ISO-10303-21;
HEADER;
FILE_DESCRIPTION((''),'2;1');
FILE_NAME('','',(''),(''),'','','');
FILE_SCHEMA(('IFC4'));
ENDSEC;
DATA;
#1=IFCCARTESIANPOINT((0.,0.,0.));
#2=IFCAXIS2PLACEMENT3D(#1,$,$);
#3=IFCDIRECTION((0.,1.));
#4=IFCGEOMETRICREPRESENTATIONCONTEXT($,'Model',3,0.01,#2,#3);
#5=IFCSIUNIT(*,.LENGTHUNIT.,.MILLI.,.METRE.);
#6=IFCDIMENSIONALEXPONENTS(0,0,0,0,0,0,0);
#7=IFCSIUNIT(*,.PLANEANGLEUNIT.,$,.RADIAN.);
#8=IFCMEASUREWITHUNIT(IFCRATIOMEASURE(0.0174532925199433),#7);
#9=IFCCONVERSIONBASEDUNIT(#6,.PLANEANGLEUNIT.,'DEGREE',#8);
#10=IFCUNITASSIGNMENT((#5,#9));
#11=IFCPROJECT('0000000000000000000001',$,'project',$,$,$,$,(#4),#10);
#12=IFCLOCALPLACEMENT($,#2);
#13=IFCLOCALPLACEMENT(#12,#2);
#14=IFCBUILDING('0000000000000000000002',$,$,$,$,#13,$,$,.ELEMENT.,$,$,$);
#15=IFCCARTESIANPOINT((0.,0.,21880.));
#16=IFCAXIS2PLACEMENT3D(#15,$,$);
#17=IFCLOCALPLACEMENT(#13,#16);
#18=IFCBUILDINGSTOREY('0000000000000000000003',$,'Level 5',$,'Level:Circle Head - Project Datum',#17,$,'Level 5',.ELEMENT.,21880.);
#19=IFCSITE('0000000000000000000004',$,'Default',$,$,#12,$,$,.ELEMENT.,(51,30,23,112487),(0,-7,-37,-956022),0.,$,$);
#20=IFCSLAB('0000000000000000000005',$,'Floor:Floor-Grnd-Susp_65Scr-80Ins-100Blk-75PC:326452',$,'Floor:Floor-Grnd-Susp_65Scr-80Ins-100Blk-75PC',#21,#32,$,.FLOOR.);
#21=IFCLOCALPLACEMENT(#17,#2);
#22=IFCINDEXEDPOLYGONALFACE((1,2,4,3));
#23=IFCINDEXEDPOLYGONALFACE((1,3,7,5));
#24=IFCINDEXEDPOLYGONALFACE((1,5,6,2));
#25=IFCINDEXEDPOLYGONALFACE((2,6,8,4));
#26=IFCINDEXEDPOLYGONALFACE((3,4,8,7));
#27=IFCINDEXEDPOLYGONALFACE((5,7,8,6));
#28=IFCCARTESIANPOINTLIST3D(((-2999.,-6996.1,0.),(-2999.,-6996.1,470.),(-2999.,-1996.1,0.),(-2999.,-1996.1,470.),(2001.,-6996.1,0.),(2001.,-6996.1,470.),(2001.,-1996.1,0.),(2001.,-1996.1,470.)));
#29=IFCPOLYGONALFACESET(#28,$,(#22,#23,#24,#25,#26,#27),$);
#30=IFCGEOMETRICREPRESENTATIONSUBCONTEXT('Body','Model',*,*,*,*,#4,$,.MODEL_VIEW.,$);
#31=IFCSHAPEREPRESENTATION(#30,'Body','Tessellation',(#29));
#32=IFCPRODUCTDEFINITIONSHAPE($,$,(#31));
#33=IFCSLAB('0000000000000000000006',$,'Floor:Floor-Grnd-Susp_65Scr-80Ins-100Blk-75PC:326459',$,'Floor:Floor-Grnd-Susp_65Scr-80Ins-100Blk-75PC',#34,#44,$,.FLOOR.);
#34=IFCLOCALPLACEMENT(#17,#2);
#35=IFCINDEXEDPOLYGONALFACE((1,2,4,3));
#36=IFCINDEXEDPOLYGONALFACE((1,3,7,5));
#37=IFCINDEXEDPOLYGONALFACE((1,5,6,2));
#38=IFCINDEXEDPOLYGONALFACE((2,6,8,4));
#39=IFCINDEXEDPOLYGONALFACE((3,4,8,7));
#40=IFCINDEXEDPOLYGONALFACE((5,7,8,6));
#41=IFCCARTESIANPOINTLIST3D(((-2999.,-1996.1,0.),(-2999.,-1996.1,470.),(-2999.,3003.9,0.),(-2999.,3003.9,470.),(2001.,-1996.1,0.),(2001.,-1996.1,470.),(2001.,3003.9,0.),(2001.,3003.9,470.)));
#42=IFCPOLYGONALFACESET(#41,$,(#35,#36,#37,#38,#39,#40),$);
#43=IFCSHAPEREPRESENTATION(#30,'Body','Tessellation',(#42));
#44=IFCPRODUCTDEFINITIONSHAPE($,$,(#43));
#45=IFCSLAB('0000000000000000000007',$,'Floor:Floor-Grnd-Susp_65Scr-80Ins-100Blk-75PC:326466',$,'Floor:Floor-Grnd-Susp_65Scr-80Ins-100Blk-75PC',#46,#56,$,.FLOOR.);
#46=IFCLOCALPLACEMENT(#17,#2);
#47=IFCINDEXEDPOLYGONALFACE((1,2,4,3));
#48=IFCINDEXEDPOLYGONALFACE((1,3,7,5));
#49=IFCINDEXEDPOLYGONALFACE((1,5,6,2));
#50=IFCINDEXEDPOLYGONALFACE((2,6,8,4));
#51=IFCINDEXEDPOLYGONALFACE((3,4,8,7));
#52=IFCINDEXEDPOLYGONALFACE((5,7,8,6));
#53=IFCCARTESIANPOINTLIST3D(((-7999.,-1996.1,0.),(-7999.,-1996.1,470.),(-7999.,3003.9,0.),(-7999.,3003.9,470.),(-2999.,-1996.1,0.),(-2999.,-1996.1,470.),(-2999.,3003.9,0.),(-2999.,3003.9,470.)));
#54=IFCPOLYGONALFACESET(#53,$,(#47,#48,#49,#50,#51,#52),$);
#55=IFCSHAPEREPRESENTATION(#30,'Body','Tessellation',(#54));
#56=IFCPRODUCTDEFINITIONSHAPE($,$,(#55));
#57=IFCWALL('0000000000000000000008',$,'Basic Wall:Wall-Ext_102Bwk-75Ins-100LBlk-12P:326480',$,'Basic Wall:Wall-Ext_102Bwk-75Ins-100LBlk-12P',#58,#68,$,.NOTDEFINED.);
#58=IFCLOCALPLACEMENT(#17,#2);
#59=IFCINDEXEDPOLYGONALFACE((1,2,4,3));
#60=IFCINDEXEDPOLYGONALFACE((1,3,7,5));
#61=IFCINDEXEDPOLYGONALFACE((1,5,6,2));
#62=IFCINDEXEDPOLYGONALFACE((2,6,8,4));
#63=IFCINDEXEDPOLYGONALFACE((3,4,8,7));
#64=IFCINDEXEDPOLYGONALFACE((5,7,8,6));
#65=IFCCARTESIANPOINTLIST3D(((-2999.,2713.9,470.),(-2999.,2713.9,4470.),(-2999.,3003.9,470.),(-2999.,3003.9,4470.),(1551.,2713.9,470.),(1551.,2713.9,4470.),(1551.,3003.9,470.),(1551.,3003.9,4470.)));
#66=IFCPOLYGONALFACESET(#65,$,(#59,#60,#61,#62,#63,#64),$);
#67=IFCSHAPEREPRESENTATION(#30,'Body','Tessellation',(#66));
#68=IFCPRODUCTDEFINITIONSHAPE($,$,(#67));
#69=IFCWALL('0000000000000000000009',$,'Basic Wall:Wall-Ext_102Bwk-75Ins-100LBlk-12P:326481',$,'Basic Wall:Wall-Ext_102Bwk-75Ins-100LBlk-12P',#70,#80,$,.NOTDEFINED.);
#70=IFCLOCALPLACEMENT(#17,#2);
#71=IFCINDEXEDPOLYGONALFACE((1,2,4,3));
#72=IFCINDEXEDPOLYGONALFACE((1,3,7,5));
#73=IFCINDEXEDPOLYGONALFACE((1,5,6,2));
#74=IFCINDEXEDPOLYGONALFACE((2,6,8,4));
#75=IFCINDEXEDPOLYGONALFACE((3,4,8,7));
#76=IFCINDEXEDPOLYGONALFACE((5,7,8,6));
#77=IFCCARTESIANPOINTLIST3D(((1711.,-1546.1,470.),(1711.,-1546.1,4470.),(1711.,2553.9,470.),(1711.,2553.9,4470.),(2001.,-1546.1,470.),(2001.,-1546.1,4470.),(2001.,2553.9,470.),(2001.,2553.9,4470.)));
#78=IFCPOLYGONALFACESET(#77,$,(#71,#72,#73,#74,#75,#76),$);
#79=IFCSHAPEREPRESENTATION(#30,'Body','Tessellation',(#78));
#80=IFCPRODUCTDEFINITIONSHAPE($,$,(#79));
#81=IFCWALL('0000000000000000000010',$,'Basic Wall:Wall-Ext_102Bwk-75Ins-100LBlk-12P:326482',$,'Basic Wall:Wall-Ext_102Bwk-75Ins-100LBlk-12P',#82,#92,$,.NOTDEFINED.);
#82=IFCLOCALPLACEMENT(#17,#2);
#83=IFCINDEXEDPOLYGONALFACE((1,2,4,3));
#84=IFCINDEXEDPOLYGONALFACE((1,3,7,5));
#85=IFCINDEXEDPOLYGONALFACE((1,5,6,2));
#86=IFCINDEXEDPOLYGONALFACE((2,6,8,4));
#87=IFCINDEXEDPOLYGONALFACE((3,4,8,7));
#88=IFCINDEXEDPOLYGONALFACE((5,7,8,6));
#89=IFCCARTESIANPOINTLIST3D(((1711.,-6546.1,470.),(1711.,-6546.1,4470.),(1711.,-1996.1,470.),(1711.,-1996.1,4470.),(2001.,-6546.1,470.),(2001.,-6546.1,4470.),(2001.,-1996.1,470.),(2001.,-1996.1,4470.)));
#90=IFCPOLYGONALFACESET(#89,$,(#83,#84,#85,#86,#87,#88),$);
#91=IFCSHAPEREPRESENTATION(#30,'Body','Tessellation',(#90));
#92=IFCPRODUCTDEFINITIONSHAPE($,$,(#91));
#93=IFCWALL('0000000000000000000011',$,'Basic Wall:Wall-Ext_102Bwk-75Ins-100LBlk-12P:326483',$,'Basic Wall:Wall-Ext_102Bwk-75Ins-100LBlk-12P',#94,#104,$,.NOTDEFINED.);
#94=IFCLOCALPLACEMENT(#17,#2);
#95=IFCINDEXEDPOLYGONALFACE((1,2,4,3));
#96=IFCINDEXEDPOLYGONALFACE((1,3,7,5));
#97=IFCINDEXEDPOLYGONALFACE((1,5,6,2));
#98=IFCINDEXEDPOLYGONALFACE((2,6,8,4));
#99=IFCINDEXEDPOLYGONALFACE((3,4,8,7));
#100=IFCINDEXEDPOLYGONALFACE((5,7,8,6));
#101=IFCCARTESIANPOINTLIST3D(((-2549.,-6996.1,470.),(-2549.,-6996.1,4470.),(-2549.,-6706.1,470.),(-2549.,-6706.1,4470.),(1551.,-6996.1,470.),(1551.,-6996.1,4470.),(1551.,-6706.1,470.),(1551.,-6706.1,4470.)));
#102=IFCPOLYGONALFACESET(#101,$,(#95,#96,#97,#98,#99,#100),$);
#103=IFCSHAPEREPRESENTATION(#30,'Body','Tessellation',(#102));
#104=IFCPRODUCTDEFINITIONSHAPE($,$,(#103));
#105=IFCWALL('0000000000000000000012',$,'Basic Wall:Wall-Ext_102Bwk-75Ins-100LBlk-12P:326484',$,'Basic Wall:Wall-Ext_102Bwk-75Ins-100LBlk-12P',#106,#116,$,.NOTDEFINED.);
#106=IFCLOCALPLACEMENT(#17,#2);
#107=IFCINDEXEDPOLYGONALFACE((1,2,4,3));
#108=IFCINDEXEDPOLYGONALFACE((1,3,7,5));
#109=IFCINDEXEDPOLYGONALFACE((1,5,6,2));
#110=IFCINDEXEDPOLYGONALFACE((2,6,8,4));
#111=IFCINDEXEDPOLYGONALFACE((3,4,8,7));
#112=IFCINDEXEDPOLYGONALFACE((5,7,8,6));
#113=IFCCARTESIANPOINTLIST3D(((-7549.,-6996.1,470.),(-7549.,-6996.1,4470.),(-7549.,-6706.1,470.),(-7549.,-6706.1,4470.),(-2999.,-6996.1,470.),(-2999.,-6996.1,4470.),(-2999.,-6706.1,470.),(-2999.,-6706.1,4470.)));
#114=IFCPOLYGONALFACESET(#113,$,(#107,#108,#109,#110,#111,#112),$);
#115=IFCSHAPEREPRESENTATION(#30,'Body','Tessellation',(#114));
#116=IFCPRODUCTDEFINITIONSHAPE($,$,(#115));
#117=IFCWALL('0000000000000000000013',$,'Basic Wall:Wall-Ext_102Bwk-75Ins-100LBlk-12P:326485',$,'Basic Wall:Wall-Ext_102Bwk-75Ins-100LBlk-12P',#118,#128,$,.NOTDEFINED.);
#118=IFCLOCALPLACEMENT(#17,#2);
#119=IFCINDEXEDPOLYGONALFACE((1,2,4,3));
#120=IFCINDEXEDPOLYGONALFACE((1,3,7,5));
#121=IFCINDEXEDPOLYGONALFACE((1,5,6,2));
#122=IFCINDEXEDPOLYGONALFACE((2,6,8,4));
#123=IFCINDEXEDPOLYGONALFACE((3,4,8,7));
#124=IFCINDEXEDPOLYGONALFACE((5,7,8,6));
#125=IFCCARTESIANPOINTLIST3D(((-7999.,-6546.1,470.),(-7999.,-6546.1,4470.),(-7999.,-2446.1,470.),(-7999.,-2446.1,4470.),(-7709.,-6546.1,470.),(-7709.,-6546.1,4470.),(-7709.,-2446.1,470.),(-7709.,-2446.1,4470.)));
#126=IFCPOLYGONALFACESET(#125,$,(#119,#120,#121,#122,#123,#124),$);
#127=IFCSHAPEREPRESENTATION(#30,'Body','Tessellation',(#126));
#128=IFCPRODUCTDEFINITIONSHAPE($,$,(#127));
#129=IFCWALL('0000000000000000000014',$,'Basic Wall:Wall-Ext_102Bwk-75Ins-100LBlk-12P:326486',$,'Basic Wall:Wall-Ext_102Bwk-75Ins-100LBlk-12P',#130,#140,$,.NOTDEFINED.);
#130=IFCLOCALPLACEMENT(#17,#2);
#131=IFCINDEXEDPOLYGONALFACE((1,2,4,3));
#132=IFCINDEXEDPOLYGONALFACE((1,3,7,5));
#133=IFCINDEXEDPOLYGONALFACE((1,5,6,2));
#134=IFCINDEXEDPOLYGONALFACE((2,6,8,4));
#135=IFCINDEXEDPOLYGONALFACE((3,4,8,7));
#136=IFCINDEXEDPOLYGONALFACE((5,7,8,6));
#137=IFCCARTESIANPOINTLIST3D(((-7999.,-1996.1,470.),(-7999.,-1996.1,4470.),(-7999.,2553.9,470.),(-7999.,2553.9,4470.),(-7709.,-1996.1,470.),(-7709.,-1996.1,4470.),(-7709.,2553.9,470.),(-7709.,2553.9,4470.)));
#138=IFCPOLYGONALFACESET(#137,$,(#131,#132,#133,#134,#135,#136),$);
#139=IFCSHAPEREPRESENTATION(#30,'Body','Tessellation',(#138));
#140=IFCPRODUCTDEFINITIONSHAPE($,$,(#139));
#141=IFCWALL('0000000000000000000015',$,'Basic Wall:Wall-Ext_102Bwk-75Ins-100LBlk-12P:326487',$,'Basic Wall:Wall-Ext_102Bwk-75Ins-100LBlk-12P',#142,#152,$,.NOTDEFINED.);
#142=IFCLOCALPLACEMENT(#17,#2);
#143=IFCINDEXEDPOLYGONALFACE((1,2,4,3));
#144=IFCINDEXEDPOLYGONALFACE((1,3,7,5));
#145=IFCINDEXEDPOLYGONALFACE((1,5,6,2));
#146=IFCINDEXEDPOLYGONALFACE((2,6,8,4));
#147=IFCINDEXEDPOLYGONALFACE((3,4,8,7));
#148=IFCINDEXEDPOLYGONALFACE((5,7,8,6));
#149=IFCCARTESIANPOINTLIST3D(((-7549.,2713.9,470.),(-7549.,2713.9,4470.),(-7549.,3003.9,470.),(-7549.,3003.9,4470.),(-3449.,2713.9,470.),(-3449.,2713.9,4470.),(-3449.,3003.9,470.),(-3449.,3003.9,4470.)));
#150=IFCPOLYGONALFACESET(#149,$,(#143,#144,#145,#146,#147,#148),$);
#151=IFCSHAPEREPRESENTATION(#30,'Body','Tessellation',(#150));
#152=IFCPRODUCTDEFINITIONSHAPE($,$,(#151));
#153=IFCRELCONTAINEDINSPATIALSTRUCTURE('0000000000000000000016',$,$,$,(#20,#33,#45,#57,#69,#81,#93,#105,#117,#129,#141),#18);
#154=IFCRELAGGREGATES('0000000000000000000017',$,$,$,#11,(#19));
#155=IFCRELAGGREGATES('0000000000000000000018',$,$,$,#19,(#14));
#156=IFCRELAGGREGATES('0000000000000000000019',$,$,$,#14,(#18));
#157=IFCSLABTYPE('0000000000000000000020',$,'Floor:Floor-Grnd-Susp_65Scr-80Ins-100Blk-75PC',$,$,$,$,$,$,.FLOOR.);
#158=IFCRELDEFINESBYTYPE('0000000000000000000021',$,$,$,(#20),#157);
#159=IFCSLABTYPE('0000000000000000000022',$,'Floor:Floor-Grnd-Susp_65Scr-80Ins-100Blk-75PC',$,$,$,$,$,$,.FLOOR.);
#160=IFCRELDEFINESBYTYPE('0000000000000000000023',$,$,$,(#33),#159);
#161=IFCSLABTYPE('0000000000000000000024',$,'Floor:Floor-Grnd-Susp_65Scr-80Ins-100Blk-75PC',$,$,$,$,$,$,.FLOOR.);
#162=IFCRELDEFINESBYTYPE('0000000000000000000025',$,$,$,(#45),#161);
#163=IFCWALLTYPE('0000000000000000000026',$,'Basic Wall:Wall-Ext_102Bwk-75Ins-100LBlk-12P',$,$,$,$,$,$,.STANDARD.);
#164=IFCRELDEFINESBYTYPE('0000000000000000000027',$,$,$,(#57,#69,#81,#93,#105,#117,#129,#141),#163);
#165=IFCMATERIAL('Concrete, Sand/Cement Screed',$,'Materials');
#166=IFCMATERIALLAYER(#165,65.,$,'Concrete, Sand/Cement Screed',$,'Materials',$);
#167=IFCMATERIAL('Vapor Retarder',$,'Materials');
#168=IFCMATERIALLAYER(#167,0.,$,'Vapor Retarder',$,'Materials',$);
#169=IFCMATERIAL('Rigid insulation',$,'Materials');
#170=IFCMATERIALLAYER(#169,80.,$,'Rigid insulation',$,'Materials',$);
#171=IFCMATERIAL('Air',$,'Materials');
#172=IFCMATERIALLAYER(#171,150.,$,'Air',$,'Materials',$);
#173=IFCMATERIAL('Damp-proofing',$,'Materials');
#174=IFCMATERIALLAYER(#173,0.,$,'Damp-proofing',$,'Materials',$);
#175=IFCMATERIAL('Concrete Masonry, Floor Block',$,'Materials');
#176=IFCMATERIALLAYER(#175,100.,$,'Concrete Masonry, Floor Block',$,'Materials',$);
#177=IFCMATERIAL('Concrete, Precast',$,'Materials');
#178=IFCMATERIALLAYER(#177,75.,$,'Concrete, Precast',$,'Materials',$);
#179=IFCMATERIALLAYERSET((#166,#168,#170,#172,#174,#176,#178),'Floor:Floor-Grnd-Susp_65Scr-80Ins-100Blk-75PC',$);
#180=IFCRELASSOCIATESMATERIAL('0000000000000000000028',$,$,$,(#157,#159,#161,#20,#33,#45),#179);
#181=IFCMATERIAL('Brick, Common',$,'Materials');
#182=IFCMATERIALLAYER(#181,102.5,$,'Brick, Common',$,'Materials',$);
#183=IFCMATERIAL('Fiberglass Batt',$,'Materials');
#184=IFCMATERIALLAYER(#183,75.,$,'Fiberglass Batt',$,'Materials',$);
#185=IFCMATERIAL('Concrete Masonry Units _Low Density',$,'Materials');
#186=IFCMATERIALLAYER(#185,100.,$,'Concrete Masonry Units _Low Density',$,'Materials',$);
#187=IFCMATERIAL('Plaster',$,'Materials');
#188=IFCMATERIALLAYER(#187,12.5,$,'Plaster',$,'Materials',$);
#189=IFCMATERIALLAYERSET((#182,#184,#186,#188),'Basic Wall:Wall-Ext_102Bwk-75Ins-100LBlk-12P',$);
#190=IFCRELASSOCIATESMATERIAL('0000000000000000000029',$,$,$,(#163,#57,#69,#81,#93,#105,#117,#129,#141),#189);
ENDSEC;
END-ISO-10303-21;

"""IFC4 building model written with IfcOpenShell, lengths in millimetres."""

from ifc_helpers import new_model, entity, si_unit, converted_unit, direction, frame, frame_2d, origin, origin_2d_with_axis, place, context, subcontext, project, spatial, rectangle, extrude, material, layer, layer_set, layer_usage, type_object, element, save


model = new_model("IFC4")

# Units and contexts
model_context = context("Model", 3, precision=0.01, world=origin(), true_north=direction((0.0, 1.0)))
body_context = subcontext(model_context, "Body", "Model", "MODEL_VIEW")
ifc_project = project(units=[si_unit("LENGTHUNIT", "METRE", prefix="MILLI"), converted_unit("PLANEANGLEUNIT", "DEGREE", entity("IfcRatioMeasure", 0.0174532925199433), si_unit("PLANEANGLEUNIT", "RADIAN"), dimensions=[0, 0, 0, 0, 0, 0, 0])], contexts=[model_context])

# Site, building, storey
site_placement = place(None, origin())
site = spatial("IfcSite", under=ifc_project, at=site_placement, Name="Default", CompositionType="ELEMENT", RefLatitude=(51, 30, 23, 112487), RefLongitude=(0, -7, -37, -956022), RefElevation=0.0)
building_placement = place(site_placement, origin())
building = spatial("IfcBuilding", under=site, at=building_placement, CompositionType="ELEMENT")
storey_placement = place(building_placement, frame((0.0, 0.0, 21880.0)))
storey = spatial("IfcBuildingStorey", under=building, at=storey_placement, Name="Level 5", ObjectType="Level:Circle Head - Project Datum", LongName="Level 5", CompositionType="ELEMENT", Elevation=21880.0)

# Slabs
ifc_material_1 = material(Name="Concrete, Sand/Cement Screed", Category="Materials")
ifc_layer_1 = layer(ifc_material_1, 65.0, Name="Concrete, Sand/Cement Screed", Category="Materials")
ifc_material_2 = material(Name="Vapor Retarder", Category="Materials")
ifc_layer_2 = layer(ifc_material_2, 0.0, Name="Vapor Retarder", Category="Materials")
ifc_material_3 = material(Name="Rigid insulation", Category="Materials")
ifc_layer_3 = layer(ifc_material_3, 80.0, Name="Rigid insulation", Category="Materials")
ifc_material_4 = material(Name="Air", Category="Materials")
ifc_layer_4 = layer(ifc_material_4, 150.0, Name="Air", Category="Materials")
ifc_material_5 = material(Name="Damp-proofing", Category="Materials")
ifc_layer_5 = layer(ifc_material_5, 0.0, Name="Damp-proofing", Category="Materials")
ifc_material_6 = material(Name="Concrete Masonry, Floor Block", Category="Materials")
ifc_layer_6 = layer(ifc_material_6, 100.0, Name="Concrete Masonry, Floor Block", Category="Materials")
ifc_material_7 = material(Name="Concrete, Precast", Category="Materials")
ifc_layer_7 = layer(ifc_material_7, 75.0, Name="Concrete, Precast", Category="Materials")
ifc_layer_set_1 = layer_set([ifc_layer_1, ifc_layer_2, ifc_layer_3, ifc_layer_4, ifc_layer_5, ifc_layer_6, ifc_layer_7], Name="Floor:Floor-Grnd-Susp_65Scr-80Ins-100Blk-75PC")
ifc_layer_usage_1 = layer_usage(ifc_layer_set_1, "AXIS3", "POSITIVE", 0.0)
slab_type_1 = type_object("IfcSlabType", Name="Floor:Floor-Grnd-Susp_65Scr-80Ins-100Blk-75PC", PredefinedType="FLOOR", material=ifc_layer_set_1)
slab_1_placement = place(storey_placement, origin())
element("IfcSlab", 1, at=slab_1_placement, inside=storey, type_object=slab_type_1, material=ifc_layer_usage_1, Name="Floor:Floor-Grnd-Susp_65Scr-80Ins-100Blk-75PC:326452", ObjectType="Floor:Floor-Grnd-Susp_65Scr-80Ins-100Blk-75PC", PredefinedType="FLOOR", context=body_context, shape_type="SweptSolid", body=[
    extrude(rectangle(XDim=5000.0, YDim=5000.0, at=frame_2d((0.0, 0.0), x_axis=(1.0, 0.0))), frame((-499.0, -4496.1, 470.0), z_axis=(0.0, 0.0, -1.0), x_axis=(0.0, 1.0, 0.0)), (0.0, 0.0, 1.0), 470.0),
])
ifc_layer_usage_2 = layer_usage(ifc_layer_set_1, "AXIS3", "POSITIVE", 0.0)
slab_type_2 = type_object("IfcSlabType", Name="Floor:Floor-Grnd-Susp_65Scr-80Ins-100Blk-75PC", PredefinedType="FLOOR", material=ifc_layer_set_1)
slab_2_placement = place(storey_placement, origin())
element("IfcSlab", 2, at=slab_2_placement, inside=storey, type_object=slab_type_2, material=ifc_layer_usage_2, Name="Floor:Floor-Grnd-Susp_65Scr-80Ins-100Blk-75PC:326459", ObjectType="Floor:Floor-Grnd-Susp_65Scr-80Ins-100Blk-75PC", PredefinedType="FLOOR", context=body_context, shape_type="SweptSolid", body=[
    extrude(rectangle(XDim=5000.0, YDim=5000.0, at=origin_2d_with_axis()), frame((-499.0, 503.9, 470.0), z_axis=(0.0, 0.0, -1.0), x_axis=(0.0, 1.0, 0.0)), (0.0, 0.0, 1.0), 470.0),
])
ifc_layer_usage_3 = layer_usage(ifc_layer_set_1, "AXIS3", "POSITIVE", 0.0)
slab_type_3 = type_object("IfcSlabType", Name="Floor:Floor-Grnd-Susp_65Scr-80Ins-100Blk-75PC", PredefinedType="FLOOR", material=ifc_layer_set_1)
slab_3_placement = place(storey_placement, origin())
element("IfcSlab", 3, at=slab_3_placement, inside=storey, type_object=slab_type_3, material=ifc_layer_usage_3, Name="Floor:Floor-Grnd-Susp_65Scr-80Ins-100Blk-75PC:326466", ObjectType="Floor:Floor-Grnd-Susp_65Scr-80Ins-100Blk-75PC", PredefinedType="FLOOR", context=body_context, shape_type="SweptSolid", body=[
    extrude(rectangle(XDim=5000.0, YDim=5000.0, at=origin_2d_with_axis()), frame((-5499.0, 503.9, 470.0), z_axis=(0.0, 0.0, -1.0), x_axis=(0.0, 1.0, 0.0)), (0.0, 0.0, 1.0), 470.0),
])

# Walls
ifc_material_8 = material(Name="Brick, Common", Category="Materials")
ifc_layer_8 = layer(ifc_material_8, 102.5, Name="Brick, Common", Category="Materials")
ifc_material_9 = material(Name="Fiberglass Batt", Category="Materials")
ifc_layer_9 = layer(ifc_material_9, 75.0, Name="Fiberglass Batt", Category="Materials")
ifc_material_10 = material(Name="Concrete Masonry Units _Low Density", Category="Materials")
ifc_layer_10 = layer(ifc_material_10, 100.0, Name="Concrete Masonry Units _Low Density", Category="Materials")
ifc_material_11 = material(Name="Plaster", Category="Materials")
ifc_layer_11 = layer(ifc_material_11, 12.5, Name="Plaster", Category="Materials")
ifc_layer_set_2 = layer_set([ifc_layer_8, ifc_layer_9, ifc_layer_10, ifc_layer_11], Name="Basic Wall:Wall-Ext_102Bwk-75Ins-100LBlk-12P")
ifc_layer_usage_4 = layer_usage(ifc_layer_set_2, "AXIS2", "NEGATIVE", 145.0)
wall_type = type_object("IfcWallType", Name="Basic Wall:Wall-Ext_102Bwk-75Ins-100LBlk-12P", PredefinedType="STANDARD", material=ifc_layer_set_2)
wall_1_placement = place(storey_placement, frame((-2999.0, 2858.9, 470.0)))
element("IfcWall", 4, at=wall_1_placement, inside=storey, type_object=wall_type, material=ifc_layer_usage_4, Name="Basic Wall:Wall-Ext_102Bwk-75Ins-100LBlk-12P:326480", ObjectType="Basic Wall:Wall-Ext_102Bwk-75Ins-100LBlk-12P", PredefinedType="NOTDEFINED", context=body_context, shape_type="SweptSolid", body=[
    extrude(rectangle(XDim=4550.0, YDim=290.0, at=frame_2d((2275.0, 0.0), x_axis=(-1.0, 0.0))), origin(), (0.0, 0.0, 1.0), 4000.0),
])
ifc_layer_usage_5 = layer_usage(ifc_layer_set_2, "AXIS2", "NEGATIVE", 145.0)
wall_2_placement = place(storey_placement, frame((1856.0, 2553.9, 470.0), z_axis=(0.0, 0.0, 1.0), x_axis=(0.0, -1.0, 0.0)))
element("IfcWall", 5, at=wall_2_placement, inside=storey, type_object=wall_type, material=ifc_layer_usage_5, Name="Basic Wall:Wall-Ext_102Bwk-75Ins-100LBlk-12P:326481", ObjectType="Basic Wall:Wall-Ext_102Bwk-75Ins-100LBlk-12P", PredefinedType="NOTDEFINED", context=body_context, shape_type="SweptSolid", body=[
    extrude(rectangle(XDim=4100.0, YDim=290.0, at=frame_2d((2050.0, 0.0), x_axis=(-1.0, 0.0))), origin(), (0.0, 0.0, 1.0), 4000.0),
])
ifc_layer_usage_6 = layer_usage(ifc_layer_set_2, "AXIS2", "NEGATIVE", 145.0)
wall_3_placement = place(storey_placement, frame((1856.0, -1996.1, 470.0), z_axis=(0.0, 0.0, 1.0), x_axis=(0.0, -1.0, 0.0)))
element("IfcWall", 6, at=wall_3_placement, inside=storey, type_object=wall_type, material=ifc_layer_usage_6, Name="Basic Wall:Wall-Ext_102Bwk-75Ins-100LBlk-12P:326482", ObjectType="Basic Wall:Wall-Ext_102Bwk-75Ins-100LBlk-12P", PredefinedType="NOTDEFINED", context=body_context, shape_type="SweptSolid", body=[
    extrude(rectangle(XDim=4550.0, YDim=290.0, at=frame_2d((2275.0, 0.0), x_axis=(-1.0, 0.0))), origin(), (0.0, 0.0, 1.0), 4000.0),
])
ifc_layer_usage_7 = layer_usage(ifc_layer_set_2, "AXIS2", "NEGATIVE", 145.0)
wall_4_placement = place(storey_placement, frame((1551.0, -6851.1, 470.0), z_axis=(0.0, 0.0, 1.0), x_axis=(-1.0, 0.0, 0.0)))
element("IfcWall", 7, at=wall_4_placement, inside=storey, type_object=wall_type, material=ifc_layer_usage_7, Name="Basic Wall:Wall-Ext_102Bwk-75Ins-100LBlk-12P:326483", ObjectType="Basic Wall:Wall-Ext_102Bwk-75Ins-100LBlk-12P", PredefinedType="NOTDEFINED", context=body_context, shape_type="SweptSolid", body=[
    extrude(rectangle(XDim=4100.0, YDim=290.0, at=frame_2d((2050.0, 0.0), x_axis=(-1.0, 0.0))), origin(), (0.0, 0.0, 1.0), 4000.0),
])
ifc_layer_usage_8 = layer_usage(ifc_layer_set_2, "AXIS2", "NEGATIVE", 145.0)
wall_5_placement = place(storey_placement, frame((-2999.0, -6851.1, 470.0), z_axis=(0.0, 0.0, 1.0), x_axis=(-1.0, 0.0, 0.0)))
element("IfcWall", 8, at=wall_5_placement, inside=storey, type_object=wall_type, material=ifc_layer_usage_8, Name="Basic Wall:Wall-Ext_102Bwk-75Ins-100LBlk-12P:326484", ObjectType="Basic Wall:Wall-Ext_102Bwk-75Ins-100LBlk-12P", PredefinedType="NOTDEFINED", context=body_context, shape_type="SweptSolid", body=[
    extrude(rectangle(XDim=4550.0, YDim=290.0, at=frame_2d((2275.0, 0.0), x_axis=(-1.0, 0.0))), origin(), (0.0, 0.0, 1.0), 4000.0),
])
ifc_layer_usage_9 = layer_usage(ifc_layer_set_2, "AXIS2", "NEGATIVE", 145.0)
wall_6_placement = place(storey_placement, frame((-7854.0, -6546.1, 470.0), z_axis=(0.0, 0.0, 1.0), x_axis=(0.0, 1.0, 0.0)))
element("IfcWall", 9, at=wall_6_placement, inside=storey, type_object=wall_type, material=ifc_layer_usage_9, Name="Basic Wall:Wall-Ext_102Bwk-75Ins-100LBlk-12P:326485", ObjectType="Basic Wall:Wall-Ext_102Bwk-75Ins-100LBlk-12P", PredefinedType="NOTDEFINED", context=body_context, shape_type="SweptSolid", body=[
    extrude(rectangle(XDim=4100.0, YDim=290.0, at=frame_2d((2050.0, 0.0), x_axis=(-1.0, 0.0))), origin(), (0.0, 0.0, 1.0), 4000.0),
])
ifc_layer_usage_10 = layer_usage(ifc_layer_set_2, "AXIS2", "NEGATIVE", 145.0)
wall_7_placement = place(storey_placement, frame((-7854.0, -1996.1, 470.0), z_axis=(0.0, 0.0, 1.0), x_axis=(0.0, 1.0, 0.0)))
element("IfcWall", 10, at=wall_7_placement, inside=storey, type_object=wall_type, material=ifc_layer_usage_10, Name="Basic Wall:Wall-Ext_102Bwk-75Ins-100LBlk-12P:326486", ObjectType="Basic Wall:Wall-Ext_102Bwk-75Ins-100LBlk-12P", PredefinedType="NOTDEFINED", context=body_context, shape_type="SweptSolid", body=[
    extrude(rectangle(XDim=4550.0, YDim=290.0, at=frame_2d((2275.0, 0.0), x_axis=(-1.0, 0.0))), origin(), (0.0, 0.0, 1.0), 4000.0),
])
ifc_layer_usage_11 = layer_usage(ifc_layer_set_2, "AXIS2", "NEGATIVE", 145.0)
wall_8_placement = place(storey_placement, frame((-7549.0, 2858.9, 470.0)))
element("IfcWall", 11, at=wall_8_placement, inside=storey, type_object=wall_type, material=ifc_layer_usage_11, Name="Basic Wall:Wall-Ext_102Bwk-75Ins-100LBlk-12P:326487", ObjectType="Basic Wall:Wall-Ext_102Bwk-75Ins-100LBlk-12P", PredefinedType="NOTDEFINED", context=body_context, shape_type="SweptSolid", body=[
    extrude(rectangle(XDim=4100.0, YDim=290.0, at=frame_2d((2050.0, 0.0), x_axis=(-1.0, 0.0))), origin(), (0.0, 0.0, 1.0), 4000.0),
])

save(model, "model.ifc")
